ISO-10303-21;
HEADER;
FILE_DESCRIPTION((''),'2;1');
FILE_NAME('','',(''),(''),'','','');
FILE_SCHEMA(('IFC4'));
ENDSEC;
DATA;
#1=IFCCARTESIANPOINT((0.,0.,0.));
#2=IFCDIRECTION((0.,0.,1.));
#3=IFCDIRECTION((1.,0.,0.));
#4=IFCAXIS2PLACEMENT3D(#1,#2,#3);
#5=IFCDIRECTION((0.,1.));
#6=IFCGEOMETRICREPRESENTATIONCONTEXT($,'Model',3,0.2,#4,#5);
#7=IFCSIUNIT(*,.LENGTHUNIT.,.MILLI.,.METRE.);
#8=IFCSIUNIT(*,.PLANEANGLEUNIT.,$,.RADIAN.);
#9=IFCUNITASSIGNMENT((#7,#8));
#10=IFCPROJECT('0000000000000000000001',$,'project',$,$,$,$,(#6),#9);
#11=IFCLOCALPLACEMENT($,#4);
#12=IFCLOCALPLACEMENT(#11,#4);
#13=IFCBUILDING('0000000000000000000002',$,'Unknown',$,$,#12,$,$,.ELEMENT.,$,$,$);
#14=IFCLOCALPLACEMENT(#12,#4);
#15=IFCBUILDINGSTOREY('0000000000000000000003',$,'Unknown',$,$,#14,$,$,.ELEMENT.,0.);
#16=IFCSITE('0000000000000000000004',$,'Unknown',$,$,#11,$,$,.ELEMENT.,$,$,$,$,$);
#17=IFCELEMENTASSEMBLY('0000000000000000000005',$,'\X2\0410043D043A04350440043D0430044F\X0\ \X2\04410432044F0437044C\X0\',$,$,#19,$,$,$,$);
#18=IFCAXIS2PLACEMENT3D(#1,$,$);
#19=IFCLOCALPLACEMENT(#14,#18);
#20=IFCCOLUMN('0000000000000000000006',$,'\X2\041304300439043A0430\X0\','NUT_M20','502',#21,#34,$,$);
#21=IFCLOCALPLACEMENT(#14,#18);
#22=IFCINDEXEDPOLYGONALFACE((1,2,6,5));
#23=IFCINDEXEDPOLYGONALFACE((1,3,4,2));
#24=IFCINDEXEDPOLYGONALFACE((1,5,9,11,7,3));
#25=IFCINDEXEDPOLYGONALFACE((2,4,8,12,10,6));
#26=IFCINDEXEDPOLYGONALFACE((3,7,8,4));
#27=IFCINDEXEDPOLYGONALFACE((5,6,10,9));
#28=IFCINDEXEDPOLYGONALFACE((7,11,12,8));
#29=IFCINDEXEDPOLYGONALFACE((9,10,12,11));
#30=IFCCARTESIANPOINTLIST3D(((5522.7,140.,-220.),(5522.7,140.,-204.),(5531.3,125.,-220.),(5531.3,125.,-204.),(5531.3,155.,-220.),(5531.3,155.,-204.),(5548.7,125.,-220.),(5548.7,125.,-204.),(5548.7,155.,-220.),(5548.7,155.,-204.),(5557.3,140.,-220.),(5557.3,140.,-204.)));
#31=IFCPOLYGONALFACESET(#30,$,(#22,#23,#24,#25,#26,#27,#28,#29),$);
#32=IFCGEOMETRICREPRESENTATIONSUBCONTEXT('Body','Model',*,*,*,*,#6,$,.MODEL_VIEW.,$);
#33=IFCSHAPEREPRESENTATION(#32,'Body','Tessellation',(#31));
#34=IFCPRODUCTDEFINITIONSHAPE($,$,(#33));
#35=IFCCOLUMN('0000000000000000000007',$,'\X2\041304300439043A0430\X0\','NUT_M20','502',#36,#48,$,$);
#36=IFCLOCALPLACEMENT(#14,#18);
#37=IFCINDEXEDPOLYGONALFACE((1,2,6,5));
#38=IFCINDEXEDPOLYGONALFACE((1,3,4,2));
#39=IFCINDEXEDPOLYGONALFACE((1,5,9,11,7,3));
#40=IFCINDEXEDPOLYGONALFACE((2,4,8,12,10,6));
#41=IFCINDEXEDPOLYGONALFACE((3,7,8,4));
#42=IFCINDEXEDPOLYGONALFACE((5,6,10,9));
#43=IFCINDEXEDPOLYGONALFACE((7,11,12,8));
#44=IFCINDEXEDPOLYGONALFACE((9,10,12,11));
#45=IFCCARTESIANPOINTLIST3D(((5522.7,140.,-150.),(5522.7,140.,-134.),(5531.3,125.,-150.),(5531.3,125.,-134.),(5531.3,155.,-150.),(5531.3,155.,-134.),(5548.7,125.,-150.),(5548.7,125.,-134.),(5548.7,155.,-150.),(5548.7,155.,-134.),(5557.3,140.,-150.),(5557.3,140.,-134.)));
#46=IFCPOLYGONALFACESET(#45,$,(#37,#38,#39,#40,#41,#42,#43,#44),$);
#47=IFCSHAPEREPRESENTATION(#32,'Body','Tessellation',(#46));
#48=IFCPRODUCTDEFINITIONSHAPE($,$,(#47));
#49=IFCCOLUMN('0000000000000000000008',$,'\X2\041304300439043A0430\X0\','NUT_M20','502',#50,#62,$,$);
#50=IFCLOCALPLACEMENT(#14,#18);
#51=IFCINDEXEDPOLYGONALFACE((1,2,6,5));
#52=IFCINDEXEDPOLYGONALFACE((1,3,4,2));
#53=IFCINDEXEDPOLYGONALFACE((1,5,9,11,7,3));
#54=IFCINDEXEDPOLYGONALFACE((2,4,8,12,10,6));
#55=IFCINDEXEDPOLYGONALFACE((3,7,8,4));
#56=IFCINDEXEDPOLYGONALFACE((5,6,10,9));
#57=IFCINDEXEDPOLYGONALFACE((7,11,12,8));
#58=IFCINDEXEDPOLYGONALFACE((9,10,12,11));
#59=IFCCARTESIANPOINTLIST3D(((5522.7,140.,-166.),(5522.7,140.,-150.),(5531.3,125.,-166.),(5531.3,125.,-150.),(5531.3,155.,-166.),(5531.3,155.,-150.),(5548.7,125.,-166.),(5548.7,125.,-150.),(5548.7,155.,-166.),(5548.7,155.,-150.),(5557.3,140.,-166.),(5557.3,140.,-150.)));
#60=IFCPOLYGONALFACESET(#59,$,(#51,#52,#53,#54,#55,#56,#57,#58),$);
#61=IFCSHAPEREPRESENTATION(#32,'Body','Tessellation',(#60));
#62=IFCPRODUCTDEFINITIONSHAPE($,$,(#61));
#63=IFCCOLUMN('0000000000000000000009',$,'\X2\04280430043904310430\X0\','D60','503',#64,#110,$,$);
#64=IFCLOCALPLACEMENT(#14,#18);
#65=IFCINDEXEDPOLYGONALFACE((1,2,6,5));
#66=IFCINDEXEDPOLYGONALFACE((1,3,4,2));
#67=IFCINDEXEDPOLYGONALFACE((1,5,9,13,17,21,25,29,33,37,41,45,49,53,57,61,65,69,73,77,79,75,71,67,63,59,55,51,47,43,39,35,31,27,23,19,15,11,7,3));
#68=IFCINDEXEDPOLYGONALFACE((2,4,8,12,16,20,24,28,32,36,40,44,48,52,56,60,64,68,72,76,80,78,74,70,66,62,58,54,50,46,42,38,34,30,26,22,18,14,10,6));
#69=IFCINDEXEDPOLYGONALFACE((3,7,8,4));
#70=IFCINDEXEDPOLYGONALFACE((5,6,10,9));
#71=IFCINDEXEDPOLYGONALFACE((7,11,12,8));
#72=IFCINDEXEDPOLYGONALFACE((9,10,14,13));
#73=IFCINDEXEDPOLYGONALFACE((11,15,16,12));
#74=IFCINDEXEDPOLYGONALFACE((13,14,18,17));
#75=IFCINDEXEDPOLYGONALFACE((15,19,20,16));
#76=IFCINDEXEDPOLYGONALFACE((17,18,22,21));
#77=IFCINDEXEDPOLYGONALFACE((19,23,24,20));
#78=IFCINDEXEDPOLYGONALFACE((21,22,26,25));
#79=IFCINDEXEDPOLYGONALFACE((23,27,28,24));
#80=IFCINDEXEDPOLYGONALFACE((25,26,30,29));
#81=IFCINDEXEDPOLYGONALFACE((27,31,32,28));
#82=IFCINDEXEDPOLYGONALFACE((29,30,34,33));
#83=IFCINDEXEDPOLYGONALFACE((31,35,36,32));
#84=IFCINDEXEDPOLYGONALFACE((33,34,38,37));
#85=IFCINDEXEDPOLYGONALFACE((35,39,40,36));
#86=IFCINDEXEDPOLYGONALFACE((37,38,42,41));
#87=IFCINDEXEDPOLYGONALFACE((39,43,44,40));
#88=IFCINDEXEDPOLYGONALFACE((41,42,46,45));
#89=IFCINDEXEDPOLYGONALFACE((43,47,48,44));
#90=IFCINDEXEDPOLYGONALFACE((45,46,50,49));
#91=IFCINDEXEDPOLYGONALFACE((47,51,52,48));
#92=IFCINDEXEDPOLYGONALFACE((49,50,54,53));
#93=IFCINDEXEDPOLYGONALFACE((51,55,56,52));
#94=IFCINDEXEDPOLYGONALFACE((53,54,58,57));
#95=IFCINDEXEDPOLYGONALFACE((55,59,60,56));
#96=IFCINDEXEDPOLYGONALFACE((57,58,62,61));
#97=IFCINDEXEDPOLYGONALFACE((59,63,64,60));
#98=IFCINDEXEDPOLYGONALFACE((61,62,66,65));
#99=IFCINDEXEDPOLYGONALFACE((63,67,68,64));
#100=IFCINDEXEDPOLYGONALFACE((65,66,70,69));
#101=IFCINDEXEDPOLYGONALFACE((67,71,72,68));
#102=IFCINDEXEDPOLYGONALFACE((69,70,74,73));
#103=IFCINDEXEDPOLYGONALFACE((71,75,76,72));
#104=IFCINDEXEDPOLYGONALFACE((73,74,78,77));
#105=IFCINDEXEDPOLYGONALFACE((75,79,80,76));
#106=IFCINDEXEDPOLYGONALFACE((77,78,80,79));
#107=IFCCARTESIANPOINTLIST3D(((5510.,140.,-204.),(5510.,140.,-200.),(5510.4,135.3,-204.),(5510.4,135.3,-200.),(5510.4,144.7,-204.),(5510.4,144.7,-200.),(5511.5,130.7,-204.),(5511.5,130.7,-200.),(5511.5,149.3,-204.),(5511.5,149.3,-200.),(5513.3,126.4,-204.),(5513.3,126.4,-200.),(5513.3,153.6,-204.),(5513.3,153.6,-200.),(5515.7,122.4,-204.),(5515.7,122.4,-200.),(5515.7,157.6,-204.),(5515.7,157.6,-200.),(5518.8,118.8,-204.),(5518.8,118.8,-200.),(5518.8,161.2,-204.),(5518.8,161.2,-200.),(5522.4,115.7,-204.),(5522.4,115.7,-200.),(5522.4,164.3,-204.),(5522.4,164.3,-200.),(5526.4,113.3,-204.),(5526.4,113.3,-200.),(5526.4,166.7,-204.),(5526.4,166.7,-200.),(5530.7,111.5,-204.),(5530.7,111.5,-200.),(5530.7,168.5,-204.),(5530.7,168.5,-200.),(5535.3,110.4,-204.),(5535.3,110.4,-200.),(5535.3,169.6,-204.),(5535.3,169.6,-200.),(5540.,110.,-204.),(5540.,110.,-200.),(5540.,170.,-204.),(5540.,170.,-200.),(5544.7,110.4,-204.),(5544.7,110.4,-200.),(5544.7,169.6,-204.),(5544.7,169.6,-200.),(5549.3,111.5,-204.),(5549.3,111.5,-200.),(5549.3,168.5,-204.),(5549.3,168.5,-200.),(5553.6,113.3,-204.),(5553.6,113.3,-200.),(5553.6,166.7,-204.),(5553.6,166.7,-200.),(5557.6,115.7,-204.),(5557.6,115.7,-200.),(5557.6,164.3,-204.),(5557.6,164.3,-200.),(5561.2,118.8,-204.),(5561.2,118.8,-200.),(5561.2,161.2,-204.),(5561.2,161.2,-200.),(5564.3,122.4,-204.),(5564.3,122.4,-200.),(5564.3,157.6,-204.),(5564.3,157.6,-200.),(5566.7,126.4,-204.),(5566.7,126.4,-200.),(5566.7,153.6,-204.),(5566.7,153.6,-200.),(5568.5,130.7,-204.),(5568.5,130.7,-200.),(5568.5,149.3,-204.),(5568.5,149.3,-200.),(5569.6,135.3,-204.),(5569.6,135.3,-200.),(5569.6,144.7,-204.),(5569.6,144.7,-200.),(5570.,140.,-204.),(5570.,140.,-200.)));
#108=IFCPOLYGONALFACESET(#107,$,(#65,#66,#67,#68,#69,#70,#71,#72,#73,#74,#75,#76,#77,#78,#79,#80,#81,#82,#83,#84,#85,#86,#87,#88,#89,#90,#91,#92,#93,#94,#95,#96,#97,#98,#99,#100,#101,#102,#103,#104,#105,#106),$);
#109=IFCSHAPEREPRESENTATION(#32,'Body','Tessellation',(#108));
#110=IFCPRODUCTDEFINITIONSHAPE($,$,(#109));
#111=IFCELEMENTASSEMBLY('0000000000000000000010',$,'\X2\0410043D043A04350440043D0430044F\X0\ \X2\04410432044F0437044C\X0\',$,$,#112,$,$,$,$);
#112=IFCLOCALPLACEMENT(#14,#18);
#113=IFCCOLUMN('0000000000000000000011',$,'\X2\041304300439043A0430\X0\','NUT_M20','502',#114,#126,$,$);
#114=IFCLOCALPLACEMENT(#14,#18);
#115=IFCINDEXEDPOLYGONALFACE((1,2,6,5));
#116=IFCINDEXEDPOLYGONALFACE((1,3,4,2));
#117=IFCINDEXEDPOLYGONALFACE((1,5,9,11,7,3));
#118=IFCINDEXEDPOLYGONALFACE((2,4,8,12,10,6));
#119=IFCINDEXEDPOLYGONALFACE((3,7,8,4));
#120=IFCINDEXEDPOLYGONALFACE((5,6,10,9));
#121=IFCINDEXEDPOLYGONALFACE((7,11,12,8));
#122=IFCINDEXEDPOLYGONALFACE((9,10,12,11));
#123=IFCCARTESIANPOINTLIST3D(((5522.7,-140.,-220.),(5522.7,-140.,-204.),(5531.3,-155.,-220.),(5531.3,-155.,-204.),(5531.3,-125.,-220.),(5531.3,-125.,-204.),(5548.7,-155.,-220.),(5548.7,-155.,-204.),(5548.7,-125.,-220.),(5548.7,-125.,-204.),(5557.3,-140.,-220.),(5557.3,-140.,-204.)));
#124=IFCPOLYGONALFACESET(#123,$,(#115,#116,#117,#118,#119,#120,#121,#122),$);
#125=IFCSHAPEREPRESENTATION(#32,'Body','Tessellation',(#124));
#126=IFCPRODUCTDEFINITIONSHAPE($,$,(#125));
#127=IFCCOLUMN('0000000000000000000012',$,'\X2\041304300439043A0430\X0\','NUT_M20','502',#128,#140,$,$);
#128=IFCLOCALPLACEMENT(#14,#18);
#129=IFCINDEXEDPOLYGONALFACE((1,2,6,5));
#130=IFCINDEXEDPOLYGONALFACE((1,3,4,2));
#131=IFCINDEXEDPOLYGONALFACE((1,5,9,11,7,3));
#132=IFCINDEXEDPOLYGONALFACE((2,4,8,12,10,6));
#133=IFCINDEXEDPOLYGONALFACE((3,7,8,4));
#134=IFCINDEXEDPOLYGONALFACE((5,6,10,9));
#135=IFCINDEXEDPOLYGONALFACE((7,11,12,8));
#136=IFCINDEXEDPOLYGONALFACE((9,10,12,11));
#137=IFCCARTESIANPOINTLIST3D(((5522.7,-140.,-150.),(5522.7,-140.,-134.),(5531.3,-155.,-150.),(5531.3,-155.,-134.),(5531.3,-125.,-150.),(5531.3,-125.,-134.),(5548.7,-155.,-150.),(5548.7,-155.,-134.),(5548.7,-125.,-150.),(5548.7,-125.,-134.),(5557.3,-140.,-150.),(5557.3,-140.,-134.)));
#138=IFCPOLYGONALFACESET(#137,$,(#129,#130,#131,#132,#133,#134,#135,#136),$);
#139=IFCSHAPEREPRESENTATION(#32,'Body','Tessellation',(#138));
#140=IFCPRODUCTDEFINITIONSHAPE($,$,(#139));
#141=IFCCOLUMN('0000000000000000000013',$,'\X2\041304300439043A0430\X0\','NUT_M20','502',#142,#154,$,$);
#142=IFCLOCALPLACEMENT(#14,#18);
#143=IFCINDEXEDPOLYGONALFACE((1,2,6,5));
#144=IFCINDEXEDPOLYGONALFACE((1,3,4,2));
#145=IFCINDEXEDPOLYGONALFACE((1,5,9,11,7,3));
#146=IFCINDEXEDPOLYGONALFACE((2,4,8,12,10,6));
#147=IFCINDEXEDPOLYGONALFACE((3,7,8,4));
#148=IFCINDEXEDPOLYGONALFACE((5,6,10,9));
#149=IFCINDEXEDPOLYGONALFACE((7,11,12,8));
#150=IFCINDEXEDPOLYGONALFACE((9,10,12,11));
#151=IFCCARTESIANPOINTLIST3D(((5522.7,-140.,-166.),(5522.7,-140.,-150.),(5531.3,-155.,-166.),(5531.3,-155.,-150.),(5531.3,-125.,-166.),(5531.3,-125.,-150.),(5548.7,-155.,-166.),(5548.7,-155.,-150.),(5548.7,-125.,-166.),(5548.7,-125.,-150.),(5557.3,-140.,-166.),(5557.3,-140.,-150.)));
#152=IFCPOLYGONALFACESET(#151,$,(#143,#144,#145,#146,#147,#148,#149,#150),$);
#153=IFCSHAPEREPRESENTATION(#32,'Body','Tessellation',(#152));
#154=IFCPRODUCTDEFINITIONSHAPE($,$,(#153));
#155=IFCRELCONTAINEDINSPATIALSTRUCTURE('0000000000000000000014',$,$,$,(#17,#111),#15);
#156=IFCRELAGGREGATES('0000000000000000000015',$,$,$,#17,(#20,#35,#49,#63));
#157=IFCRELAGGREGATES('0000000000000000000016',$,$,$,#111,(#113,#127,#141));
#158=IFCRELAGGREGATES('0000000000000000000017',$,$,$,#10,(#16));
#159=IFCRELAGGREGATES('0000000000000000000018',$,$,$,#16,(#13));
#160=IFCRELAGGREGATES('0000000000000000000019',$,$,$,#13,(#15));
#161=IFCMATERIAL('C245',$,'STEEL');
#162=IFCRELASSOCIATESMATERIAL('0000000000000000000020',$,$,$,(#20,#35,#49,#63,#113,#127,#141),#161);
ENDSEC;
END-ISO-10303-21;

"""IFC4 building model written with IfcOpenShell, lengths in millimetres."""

from ifc_helpers import new_model, si_unit, direction, frame, origin_with_axes, place, context, subcontext, project, spatial, line, indexed_curve, outline, extrude, material, element, aggregate, save


model = new_model("IFC4")

# Units and contexts
model_context = context("Model", 3, precision=0.2, world=origin_with_axes(), true_north=direction((0.0, 1.0)))
body_context = subcontext(model_context, "Body", "Model", "MODEL_VIEW")
ifc_project = project(units=[si_unit("LENGTHUNIT", "METRE", prefix="MILLI"), si_unit("PLANEANGLEUNIT", "RADIAN")], contexts=[model_context])

# Site, building, storey
site_placement = place(None, origin_with_axes())
site = spatial("IfcSite", under=ifc_project, at=site_placement, Name="Unknown", CompositionType="ELEMENT")
building_placement = place(site_placement, origin_with_axes())
building = spatial("IfcBuilding", under=site, at=building_placement, Name="Unknown", CompositionType="ELEMENT")
storey_placement = place(building_placement, origin_with_axes())
storey = spatial("IfcBuildingStorey", under=building, at=storey_placement, Name="Unknown", CompositionType="ELEMENT", Elevation=0.0)

# Element assemblies, columns
assembly_1_placement = place(storey_placement, frame((5540.0, 140.0, -125.0), z_axis=(-1.0, 0.0, 0.0), x_axis=(0.0, 0.0, -1.0)))
assembly_1 = element("IfcElementAssembly", 1, at=assembly_1_placement, inside=storey, Name="Анкерная связь")
ifc_material_1 = material(Name="C245", Category="STEEL")
column_1_placement = place(assembly_1_placement, frame((79.0, 0.0, 0.0), z_axis=(0.0, 0.0, -1.0), x_axis=(1.0, 0.0, 0.0)))
column_1 = element("IfcColumn", 2, at=column_1_placement, material=ifc_material_1, Name="Гайка", Description="NUT_M20", ObjectType="502", context=body_context, shape_type="SolidModel", body=[
    extrude(outline(indexed_curve([(8.7, -15.0), (17.3, 0.0), (8.7, 15.0), (-8.7, 15.0), (-17.3, 0.0), (-8.7, -15.0)], segments=[line(1, 2, 3, 4, 5, 6, 1)])), frame((0.0, 0.0, 0.0), z_axis=(-1.0, 0.0, 0.0), x_axis=(0.0, 0.0, 1.0)), (0.0, 0.0, -1.0), 16.0),
])
column_2_placement = place(assembly_1_placement, frame((9.0, 0.0, 0.0), z_axis=(0.0, 0.0, -1.0), x_axis=(1.0, 0.0, 0.0)))
column_2 = element("IfcColumn", 3, at=column_2_placement, material=ifc_material_1, Name="Гайка", Description="NUT_M20", ObjectType="502", context=body_context, shape_type="SolidModel", body=[
    extrude(outline(indexed_curve([(8.7, -15.0), (17.3, 0.0), (8.7, 15.0), (-8.7, 15.0), (-17.3, 0.0), (-8.7, -15.0)], segments=[line(1, 2, 3, 4, 5, 6, 1)])), frame((0.0, 0.0, 0.0), z_axis=(-1.0, 0.0, 0.0), x_axis=(0.0, 0.0, 1.0)), (0.0, 0.0, -1.0), 16.0),
])
column_3_placement = place(assembly_1_placement, frame((25.0, 0.0, 0.0), z_axis=(0.0, 0.0, -1.0), x_axis=(1.0, 0.0, 0.0)))
column_3 = element("IfcColumn", 4, at=column_3_placement, material=ifc_material_1, Name="Гайка", Description="NUT_M20", ObjectType="502", context=body_context, shape_type="SolidModel", body=[
    extrude(outline(indexed_curve([(8.7, -15.0), (17.3, 0.0), (8.7, 15.0), (-8.7, 15.0), (-17.3, 0.0), (-8.7, -15.0)], segments=[line(1, 2, 3, 4, 5, 6, 1)])), frame((0.0, 0.0, 0.0), z_axis=(-1.0, 0.0, 0.0), x_axis=(0.0, 0.0, 1.0)), (0.0, 0.0, -1.0), 16.0),
])
column_4_placement = place(assembly_1_placement, frame((75.0, 0.0, 0.0), z_axis=(0.0, -1.0, 0.0), x_axis=(1.0, 0.0, 0.0)))
column_4 = element("IfcColumn", 5, at=column_4_placement, material=ifc_material_1, Name="Шайба", Description="D60", ObjectType="503", context=body_context, shape_type="SolidModel", body=[
    extrude(outline(indexed_curve([(30.0, 0.0), (29.6, 4.7), (28.5, 9.3), (26.7, 13.6), (24.3, 17.6), (21.2, 21.2), (17.6, 24.3), (13.6, 26.7), (9.3, 28.5), (4.7, 29.6), (0.0, 30.0), (-4.7, 29.6), (-9.3, 28.5), (-13.6, 26.7), (-17.6, 24.3), (-21.2, 21.2), (-24.3, 17.6), (-26.7, 13.6), (-28.5, 9.3), (-29.6, 4.7), (-30.0, 0.0), (-29.6, -4.7), (-28.5, -9.3), (-26.7, -13.6), (-24.3, -17.6), (-21.2, -21.2), (-17.6, -24.3), (-13.6, -26.7), (-9.3, -28.5), (-4.7, -29.6), (0.0, -30.0), (4.7, -29.6), (9.3, -28.5), (13.6, -26.7), (17.6, -24.3), (21.2, -21.2), (24.3, -17.6), (26.7, -13.6), (28.5, -9.3), (29.6, -4.7)], segments=[line(1, 2, 3, 4, 5, 6, 7, 8, 9, 10, 11, 12, 13, 14, 15, 16, 17, 18, 19, 20, 21, 22, 23, 24, 25, 26, 27, 28, 29, 30, 31, 32, 33, 34, 35, 36, 37, 38, 39, 40, 1)])), frame((0.0, 0.0, 0.0), z_axis=(-1.0, 0.0, 0.0), x_axis=(0.0, 0.0, 1.0)), (0.0, 0.0, -1.0), 4.0),
])
assembly_2_placement = place(storey_placement, frame((5540.0, -140.0, -125.0), z_axis=(1.0, 0.0, 0.0), x_axis=(0.0, 0.0, -1.0)))
assembly_2 = element("IfcElementAssembly", 6, at=assembly_2_placement, inside=storey, Name="Анкерная связь")
column_5_placement = place(assembly_2_placement, frame((79.0, 0.0, 0.0), z_axis=(0.0, 0.0, 1.0), x_axis=(1.0, 0.0, 0.0)))
column_5 = element("IfcColumn", 7, at=column_5_placement, material=ifc_material_1, Name="Гайка", Description="NUT_M20", ObjectType="502", context=body_context, shape_type="SolidModel", body=[
    extrude(outline(indexed_curve([(8.7, -15.0), (17.3, 0.0), (8.7, 15.0), (-8.7, 15.0), (-17.3, 0.0), (-8.7, -15.0)], segments=[line(1, 2, 3, 4, 5, 6, 1)])), frame((0.0, 0.0, 0.0), z_axis=(-1.0, 0.0, 0.0), x_axis=(0.0, 0.0, 1.0)), (0.0, 0.0, -1.0), 16.0),
])
column_6_placement = place(assembly_2_placement, frame((9.0, 0.0, 0.0), z_axis=(0.0, 0.0, 1.0), x_axis=(1.0, 0.0, 0.0)))
column_6 = element("IfcColumn", 8, at=column_6_placement, material=ifc_material_1, Name="Гайка", Description="NUT_M20", ObjectType="502", context=body_context, shape_type="SolidModel", body=[
    extrude(outline(indexed_curve([(8.7, -15.0), (17.3, 0.0), (8.7, 15.0), (-8.7, 15.0), (-17.3, 0.0), (-8.7, -15.0)], segments=[line(1, 2, 3, 4, 5, 6, 1)])), frame((0.0, 0.0, 0.0), z_axis=(-1.0, 0.0, 0.0), x_axis=(0.0, 0.0, 1.0)), (0.0, 0.0, -1.0), 16.0),
])
column_7_placement = place(assembly_2_placement, frame((25.0, 0.0, 0.0), z_axis=(0.0, 0.0, 1.0), x_axis=(1.0, 0.0, 0.0)))
column_7 = element("IfcColumn", 9, at=column_7_placement, material=ifc_material_1, Name="Гайка", Description="NUT_M20", ObjectType="502", context=body_context, shape_type="SolidModel", body=[
    extrude(outline(indexed_curve([(8.7, -15.0), (17.3, 0.0), (8.7, 15.0), (-8.7, 15.0), (-17.3, 0.0), (-8.7, -15.0)], segments=[line(1, 2, 3, 4, 5, 6, 1)])), frame((0.0, 0.0, 0.0), z_axis=(-1.0, 0.0, 0.0), x_axis=(0.0, 0.0, 1.0)), (0.0, 0.0, -1.0), 16.0),
])

aggregate(assembly_1, [column_1, column_2, column_3, column_4])
aggregate(assembly_2, [column_5, column_6, column_7])

save(model, "model.ifc")
